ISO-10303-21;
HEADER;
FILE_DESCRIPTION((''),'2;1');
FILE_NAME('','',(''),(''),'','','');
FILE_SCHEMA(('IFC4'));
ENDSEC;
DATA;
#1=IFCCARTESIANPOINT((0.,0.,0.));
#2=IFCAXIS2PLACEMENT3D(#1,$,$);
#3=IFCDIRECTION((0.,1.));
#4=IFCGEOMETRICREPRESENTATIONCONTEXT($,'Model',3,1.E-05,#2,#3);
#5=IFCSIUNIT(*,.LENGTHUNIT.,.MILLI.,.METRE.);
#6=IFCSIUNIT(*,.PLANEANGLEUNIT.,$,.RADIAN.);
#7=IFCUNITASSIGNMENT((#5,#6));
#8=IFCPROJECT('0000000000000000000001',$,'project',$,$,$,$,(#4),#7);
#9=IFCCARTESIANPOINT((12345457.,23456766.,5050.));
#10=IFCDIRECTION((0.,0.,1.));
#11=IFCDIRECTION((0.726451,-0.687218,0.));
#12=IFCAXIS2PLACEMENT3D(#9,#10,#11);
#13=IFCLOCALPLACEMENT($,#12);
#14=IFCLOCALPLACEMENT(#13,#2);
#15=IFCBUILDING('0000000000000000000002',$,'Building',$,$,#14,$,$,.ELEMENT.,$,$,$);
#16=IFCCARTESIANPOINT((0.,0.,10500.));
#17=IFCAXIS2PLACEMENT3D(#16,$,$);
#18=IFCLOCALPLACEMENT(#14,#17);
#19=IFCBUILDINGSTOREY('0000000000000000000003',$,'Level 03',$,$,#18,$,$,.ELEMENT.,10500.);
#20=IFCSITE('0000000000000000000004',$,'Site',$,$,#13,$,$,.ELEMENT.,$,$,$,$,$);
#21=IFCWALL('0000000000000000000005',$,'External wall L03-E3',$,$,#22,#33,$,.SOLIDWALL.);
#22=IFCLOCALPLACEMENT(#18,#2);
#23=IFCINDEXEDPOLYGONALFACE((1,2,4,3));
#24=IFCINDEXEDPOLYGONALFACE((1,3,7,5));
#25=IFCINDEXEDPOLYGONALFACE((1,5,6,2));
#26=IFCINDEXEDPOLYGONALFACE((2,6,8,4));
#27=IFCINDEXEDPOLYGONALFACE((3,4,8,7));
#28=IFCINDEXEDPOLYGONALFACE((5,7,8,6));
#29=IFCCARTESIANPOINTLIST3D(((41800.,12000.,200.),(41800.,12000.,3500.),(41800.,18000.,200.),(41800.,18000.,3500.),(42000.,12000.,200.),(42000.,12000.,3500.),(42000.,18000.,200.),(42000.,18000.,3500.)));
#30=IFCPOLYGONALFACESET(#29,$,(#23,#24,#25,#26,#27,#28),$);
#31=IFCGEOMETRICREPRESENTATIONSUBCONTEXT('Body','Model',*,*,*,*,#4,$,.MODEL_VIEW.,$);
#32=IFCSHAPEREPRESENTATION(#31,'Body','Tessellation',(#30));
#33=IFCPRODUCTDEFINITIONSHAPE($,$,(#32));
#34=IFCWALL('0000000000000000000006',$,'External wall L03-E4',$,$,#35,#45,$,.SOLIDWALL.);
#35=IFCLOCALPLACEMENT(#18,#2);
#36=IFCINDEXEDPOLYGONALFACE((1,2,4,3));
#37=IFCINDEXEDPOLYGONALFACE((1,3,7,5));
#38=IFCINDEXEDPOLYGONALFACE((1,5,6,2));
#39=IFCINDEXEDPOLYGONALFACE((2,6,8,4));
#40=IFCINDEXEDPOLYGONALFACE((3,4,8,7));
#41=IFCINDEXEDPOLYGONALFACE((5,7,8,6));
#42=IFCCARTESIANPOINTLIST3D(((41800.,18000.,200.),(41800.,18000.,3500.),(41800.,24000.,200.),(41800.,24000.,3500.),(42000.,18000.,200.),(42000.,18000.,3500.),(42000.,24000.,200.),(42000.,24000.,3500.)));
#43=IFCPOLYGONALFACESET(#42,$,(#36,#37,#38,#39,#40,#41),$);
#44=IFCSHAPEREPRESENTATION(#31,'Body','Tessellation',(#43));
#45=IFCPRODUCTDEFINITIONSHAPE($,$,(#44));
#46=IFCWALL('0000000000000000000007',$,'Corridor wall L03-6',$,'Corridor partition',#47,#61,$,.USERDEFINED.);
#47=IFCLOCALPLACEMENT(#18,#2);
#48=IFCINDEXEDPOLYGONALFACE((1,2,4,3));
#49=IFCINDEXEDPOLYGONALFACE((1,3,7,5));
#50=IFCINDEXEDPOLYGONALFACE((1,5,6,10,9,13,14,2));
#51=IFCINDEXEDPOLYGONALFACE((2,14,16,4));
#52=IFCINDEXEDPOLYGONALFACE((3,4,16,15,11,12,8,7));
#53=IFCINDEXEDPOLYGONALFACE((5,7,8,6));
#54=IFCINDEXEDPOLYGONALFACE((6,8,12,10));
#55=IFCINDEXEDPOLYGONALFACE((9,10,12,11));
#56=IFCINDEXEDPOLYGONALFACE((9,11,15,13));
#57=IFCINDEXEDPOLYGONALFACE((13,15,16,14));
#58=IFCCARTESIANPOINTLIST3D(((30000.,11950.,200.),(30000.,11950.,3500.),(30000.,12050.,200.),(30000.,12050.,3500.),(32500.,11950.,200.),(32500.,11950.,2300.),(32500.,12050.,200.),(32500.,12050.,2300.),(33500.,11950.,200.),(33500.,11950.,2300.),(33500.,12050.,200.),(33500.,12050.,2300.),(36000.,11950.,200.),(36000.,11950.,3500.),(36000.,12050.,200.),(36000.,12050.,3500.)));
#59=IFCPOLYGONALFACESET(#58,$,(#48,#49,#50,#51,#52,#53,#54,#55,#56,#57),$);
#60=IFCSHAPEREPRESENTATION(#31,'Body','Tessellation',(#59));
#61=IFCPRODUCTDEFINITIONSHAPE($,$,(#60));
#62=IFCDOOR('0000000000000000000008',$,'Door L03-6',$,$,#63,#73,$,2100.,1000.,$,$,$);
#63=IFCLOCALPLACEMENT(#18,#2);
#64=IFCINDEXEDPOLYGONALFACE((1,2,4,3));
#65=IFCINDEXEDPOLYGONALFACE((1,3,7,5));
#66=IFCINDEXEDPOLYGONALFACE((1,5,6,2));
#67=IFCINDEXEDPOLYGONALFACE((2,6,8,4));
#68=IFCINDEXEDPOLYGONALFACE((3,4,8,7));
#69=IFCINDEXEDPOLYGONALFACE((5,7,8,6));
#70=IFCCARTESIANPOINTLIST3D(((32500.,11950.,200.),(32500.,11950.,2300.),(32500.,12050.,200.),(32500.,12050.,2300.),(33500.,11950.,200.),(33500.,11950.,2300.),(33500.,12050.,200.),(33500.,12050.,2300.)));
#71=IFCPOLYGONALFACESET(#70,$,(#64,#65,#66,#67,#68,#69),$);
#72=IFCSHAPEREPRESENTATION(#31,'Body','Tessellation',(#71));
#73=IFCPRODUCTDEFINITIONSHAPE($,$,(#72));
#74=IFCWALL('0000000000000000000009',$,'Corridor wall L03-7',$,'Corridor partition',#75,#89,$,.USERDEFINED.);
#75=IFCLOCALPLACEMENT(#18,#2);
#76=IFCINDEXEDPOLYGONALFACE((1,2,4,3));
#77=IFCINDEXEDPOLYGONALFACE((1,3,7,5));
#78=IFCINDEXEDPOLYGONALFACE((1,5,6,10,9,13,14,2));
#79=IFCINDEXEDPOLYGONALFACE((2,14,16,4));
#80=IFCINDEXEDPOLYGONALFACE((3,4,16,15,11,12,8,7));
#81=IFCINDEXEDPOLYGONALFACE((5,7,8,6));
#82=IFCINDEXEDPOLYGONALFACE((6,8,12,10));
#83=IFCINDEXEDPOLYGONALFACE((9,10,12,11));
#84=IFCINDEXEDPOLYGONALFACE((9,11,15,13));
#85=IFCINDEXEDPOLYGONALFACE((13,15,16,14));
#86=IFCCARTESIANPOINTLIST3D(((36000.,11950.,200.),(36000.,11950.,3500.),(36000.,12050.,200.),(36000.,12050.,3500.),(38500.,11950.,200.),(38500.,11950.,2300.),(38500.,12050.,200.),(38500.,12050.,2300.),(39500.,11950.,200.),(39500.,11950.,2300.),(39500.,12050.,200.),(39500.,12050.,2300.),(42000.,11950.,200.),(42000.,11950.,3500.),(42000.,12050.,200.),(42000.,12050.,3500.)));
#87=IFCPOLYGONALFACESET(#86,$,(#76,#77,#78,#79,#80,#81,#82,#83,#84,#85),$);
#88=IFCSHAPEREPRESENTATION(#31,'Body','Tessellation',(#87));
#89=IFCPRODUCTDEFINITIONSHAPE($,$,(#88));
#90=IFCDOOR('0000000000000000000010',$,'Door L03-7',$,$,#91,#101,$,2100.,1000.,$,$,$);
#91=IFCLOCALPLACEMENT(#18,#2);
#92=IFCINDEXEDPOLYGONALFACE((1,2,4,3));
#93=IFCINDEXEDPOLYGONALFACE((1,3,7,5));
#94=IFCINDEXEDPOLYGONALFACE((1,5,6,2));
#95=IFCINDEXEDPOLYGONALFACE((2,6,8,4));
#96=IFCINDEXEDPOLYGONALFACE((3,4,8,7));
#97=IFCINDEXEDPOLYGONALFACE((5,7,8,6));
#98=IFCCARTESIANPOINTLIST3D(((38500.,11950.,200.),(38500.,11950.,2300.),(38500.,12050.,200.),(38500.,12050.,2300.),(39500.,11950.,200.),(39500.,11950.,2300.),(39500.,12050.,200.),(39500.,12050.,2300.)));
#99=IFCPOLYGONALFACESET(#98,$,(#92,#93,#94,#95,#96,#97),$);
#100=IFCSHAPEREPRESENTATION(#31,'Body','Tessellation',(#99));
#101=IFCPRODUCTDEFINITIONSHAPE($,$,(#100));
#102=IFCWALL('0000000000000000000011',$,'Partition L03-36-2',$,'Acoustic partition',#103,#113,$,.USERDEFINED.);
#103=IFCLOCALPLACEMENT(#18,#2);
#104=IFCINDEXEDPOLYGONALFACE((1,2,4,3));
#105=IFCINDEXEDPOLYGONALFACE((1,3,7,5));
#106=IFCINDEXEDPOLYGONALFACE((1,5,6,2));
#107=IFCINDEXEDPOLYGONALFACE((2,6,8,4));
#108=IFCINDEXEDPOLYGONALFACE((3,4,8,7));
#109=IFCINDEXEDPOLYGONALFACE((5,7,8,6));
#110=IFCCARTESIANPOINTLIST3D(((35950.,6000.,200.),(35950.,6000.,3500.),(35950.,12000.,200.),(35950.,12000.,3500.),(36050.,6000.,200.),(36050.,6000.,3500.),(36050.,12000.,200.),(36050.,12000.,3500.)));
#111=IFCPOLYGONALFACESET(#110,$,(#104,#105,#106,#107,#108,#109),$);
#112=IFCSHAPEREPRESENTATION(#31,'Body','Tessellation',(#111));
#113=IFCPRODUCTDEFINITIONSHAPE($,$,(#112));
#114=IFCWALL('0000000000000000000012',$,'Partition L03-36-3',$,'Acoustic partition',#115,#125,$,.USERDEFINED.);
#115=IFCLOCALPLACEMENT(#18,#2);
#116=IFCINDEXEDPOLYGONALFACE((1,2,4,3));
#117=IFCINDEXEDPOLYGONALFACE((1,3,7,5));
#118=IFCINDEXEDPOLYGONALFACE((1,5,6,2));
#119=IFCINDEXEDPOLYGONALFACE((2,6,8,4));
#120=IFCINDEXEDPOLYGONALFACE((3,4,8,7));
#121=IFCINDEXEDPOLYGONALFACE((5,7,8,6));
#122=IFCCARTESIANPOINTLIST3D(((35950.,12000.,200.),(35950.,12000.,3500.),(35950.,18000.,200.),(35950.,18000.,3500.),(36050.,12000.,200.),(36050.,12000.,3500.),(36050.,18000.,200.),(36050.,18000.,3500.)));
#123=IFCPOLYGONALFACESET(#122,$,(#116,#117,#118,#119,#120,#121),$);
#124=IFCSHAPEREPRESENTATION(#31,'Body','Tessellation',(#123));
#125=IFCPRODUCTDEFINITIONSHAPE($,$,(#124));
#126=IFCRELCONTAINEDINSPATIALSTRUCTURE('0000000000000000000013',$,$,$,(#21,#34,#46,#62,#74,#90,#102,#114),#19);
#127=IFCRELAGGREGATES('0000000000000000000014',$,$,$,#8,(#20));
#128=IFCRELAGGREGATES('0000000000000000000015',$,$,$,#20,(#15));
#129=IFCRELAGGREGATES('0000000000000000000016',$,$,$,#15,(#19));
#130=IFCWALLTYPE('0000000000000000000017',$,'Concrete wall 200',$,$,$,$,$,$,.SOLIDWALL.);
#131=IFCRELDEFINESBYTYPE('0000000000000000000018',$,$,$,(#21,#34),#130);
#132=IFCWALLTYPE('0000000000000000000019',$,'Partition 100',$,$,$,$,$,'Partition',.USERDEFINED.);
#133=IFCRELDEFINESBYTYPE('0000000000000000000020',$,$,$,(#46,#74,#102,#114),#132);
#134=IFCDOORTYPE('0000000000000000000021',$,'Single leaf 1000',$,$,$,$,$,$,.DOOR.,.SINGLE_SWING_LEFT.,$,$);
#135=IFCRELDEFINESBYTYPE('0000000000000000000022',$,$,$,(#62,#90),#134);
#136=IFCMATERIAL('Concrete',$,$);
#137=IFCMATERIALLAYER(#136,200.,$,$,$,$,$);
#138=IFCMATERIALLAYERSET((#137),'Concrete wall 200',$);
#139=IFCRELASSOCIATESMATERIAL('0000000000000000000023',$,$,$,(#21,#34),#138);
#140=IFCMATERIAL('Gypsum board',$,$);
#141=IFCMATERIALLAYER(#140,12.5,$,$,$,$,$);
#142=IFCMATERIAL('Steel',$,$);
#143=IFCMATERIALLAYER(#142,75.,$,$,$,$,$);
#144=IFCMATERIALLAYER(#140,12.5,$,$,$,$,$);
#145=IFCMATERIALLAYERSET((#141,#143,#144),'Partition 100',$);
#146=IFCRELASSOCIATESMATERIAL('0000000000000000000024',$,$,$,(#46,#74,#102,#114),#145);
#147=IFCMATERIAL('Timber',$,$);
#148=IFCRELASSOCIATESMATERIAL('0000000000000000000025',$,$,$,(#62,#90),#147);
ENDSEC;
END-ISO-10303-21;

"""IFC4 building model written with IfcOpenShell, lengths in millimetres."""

from ifc_helpers import new_model, si_unit, direction, frame, origin, place, context, subcontext, project, spatial, rectangle, extrude, source, transform, mapped, material, layer, layer_set, layer_usage, type_object, type_shapes, element, fill, save


model = new_model("IFC4")

# Units and contexts
model_context = context("Model", 3, precision=1e-05, world=origin(), true_north=direction((0.0, 1.0)))
body_context = subcontext(model_context, "Body", "Model", "MODEL_VIEW")
ifc_project = project(units=[si_unit("LENGTHUNIT", "METRE", prefix="MILLI"), si_unit("PLANEANGLEUNIT", "RADIAN")], contexts=[model_context])

# Site, building, storey
site_placement = place(None, frame((12345457.0, 23456766.0, 5050.0), z_axis=(0.0, 0.0, 1.0), x_axis=(0.726451, -0.687218, 0.0)))
site = spatial("IfcSite", under=ifc_project, at=site_placement, Name="Site", CompositionType="ELEMENT")
building_placement = place(site_placement, origin())
building = spatial("IfcBuilding", under=site, at=building_placement, Name="Building", CompositionType="ELEMENT")
storey_placement = place(building_placement, frame((0.0, 0.0, 10500.0)))
storey = spatial("IfcBuildingStorey", under=building, at=storey_placement, Name="Level 03", CompositionType="ELEMENT", Elevation=10500.0)

# Shared definitions
ifc_material_1 = material(Name="Steel")

# Shared definitions
ifc_material_2 = material(Name="Concrete")

# Walls
ifc_layer_1 = layer(ifc_material_2, 200.0)
ifc_layer_set_1 = layer_set([ifc_layer_1], Name="Concrete wall 200")
ifc_layer_usage_1 = layer_usage(ifc_layer_set_1, "AXIS2", "POSITIVE", 0.0)
wall_type_1 = type_object("IfcWallType", Name="Concrete wall 200", PredefinedType="SOLIDWALL")
for number, where, name in (
    (1, (41800.0, 12000.0, 200.0), "External wall L03-E3"),
    (2, (41800.0, 18000.0, 200.0), "External wall L03-E4"),
):
    element("IfcWall", number, at=place(storey_placement, frame(where)), inside=storey, type_object=wall_type_1, material=ifc_layer_usage_1, Name=name, PredefinedType="SOLIDWALL", context=body_context, shape_type="SweptSolid", body=[
        extrude(rectangle(XDim=200.0, YDim=6000.0), frame((100.0, 3000.0, 0.0)), (0.0, 0.0, 1.0), 3300.0),
    ])

# Walls, openings, doors
ifc_material_3 = material(Name="Gypsum board")
ifc_layer_2 = layer(ifc_material_3, 12.5)
ifc_layer_3 = layer(ifc_material_1, 75.0)
ifc_layer_4 = layer(ifc_material_3, 12.5)
ifc_layer_set_2 = layer_set([ifc_layer_2, ifc_layer_3, ifc_layer_4], Name="Partition 100")
ifc_layer_usage_2 = layer_usage(ifc_layer_set_2, "AXIS2", "POSITIVE", 0.0)
wall_type_2 = type_object("IfcWallType", Name="Partition 100", ElementType="Partition", PredefinedType="USERDEFINED")
wall_1_placement = place(storey_placement, frame((30000.0, 11950.0, 200.0)))
wall_1 = element("IfcWall", 3, at=wall_1_placement, inside=storey, type_object=wall_type_2, material=ifc_layer_usage_2, Name="Corridor wall L03-6", ObjectType="Corridor partition", PredefinedType="USERDEFINED", context=body_context, shape_type="SweptSolid", body=[
    extrude(rectangle(XDim=6000.0, YDim=100.0), frame((3000.0, 50.0, 0.0)), (0.0, 0.0, 1.0), 3300.0),
])
opening_1_placement = place(wall_1_placement, frame((2500.0, -50.0, 0.0)))
opening_1 = element("IfcOpeningElement", 4, at=opening_1_placement, cuts=wall_1, PredefinedType="OPENING", context=body_context, shape_type="SweptSolid", body=[
    extrude(rectangle(XDim=1000.0, YDim=200.0), frame((500.0, 100.0, 0.0)), (0.0, 0.0, 1.0), 2100.0),
])
ifc_material_4 = material(Name="Timber")
door_type = type_object("IfcDoorType", Name="Single leaf 1000", OperationType="SINGLE_SWING_LEFT", PredefinedType="DOOR")
shared_shape = source(origin(), body_context, "Body", "SweptSolid", [
    extrude(rectangle(XDim=1000.0, YDim=100.0), frame((500.0, 50.0, 0.0)), (0.0, 0.0, 1.0), 2100.0),
])
type_shapes(door_type, [shared_shape])
door_1_placement = place(storey_placement, frame((32500.0, 11950.0, 200.0)))
door_1 = element("IfcDoor", 5, at=door_1_placement, inside=storey, type_object=door_type, material=ifc_material_4, Name="Door L03-6", OverallHeight=2100.0, OverallWidth=1000.0, context=body_context, shape_type="MappedRepresentation", body=[
    mapped(shared_shape, transform((0.0, 0.0, 0.0))),
])
fill(opening_1, door_1)
wall_2_placement = place(storey_placement, frame((36000.0, 11950.0, 200.0)))
wall_2 = element("IfcWall", 6, at=wall_2_placement, inside=storey, type_object=wall_type_2, material=ifc_layer_usage_2, Name="Corridor wall L03-7", ObjectType="Corridor partition", PredefinedType="USERDEFINED", context=body_context, shape_type="SweptSolid", body=[
    extrude(rectangle(XDim=6000.0, YDim=100.0), frame((3000.0, 50.0, 0.0)), (0.0, 0.0, 1.0), 3300.0),
])
opening_2_placement = place(wall_2_placement, frame((2500.0, -50.0, 0.0)))
opening_2 = element("IfcOpeningElement", 7, at=opening_2_placement, cuts=wall_2, PredefinedType="OPENING", context=body_context, shape_type="SweptSolid", body=[
    extrude(rectangle(XDim=1000.0, YDim=200.0), frame((500.0, 100.0, 0.0)), (0.0, 0.0, 1.0), 2100.0),
])
door_2_placement = place(storey_placement, frame((38500.0, 11950.0, 200.0)))
door_2 = element("IfcDoor", 8, at=door_2_placement, inside=storey, type_object=door_type, material=ifc_material_4, Name="Door L03-7", OverallHeight=2100.0, OverallWidth=1000.0, context=body_context, shape_type="MappedRepresentation", body=[
    mapped(shared_shape, transform((0.0, 0.0, 0.0))),
])
fill(opening_2, door_2)

# Walls
for number, where, name in (
    (9, (35950.0, 6000.0, 200.0), "Partition L03-36-2"),
    (10, (35950.0, 12000.0, 200.0), "Partition L03-36-3"),
):
    element("IfcWall", number, at=place(storey_placement, frame(where)), inside=storey, type_object=wall_type_2, material=ifc_layer_usage_2, Name=name, ObjectType="Acoustic partition", PredefinedType="USERDEFINED", context=body_context, shape_type="SweptSolid", body=[
        extrude(rectangle(XDim=100.0, YDim=6000.0), frame((50.0, 3000.0, 0.0)), (0.0, 0.0, 1.0), 3300.0),
    ])

save(model, "model.ifc")
